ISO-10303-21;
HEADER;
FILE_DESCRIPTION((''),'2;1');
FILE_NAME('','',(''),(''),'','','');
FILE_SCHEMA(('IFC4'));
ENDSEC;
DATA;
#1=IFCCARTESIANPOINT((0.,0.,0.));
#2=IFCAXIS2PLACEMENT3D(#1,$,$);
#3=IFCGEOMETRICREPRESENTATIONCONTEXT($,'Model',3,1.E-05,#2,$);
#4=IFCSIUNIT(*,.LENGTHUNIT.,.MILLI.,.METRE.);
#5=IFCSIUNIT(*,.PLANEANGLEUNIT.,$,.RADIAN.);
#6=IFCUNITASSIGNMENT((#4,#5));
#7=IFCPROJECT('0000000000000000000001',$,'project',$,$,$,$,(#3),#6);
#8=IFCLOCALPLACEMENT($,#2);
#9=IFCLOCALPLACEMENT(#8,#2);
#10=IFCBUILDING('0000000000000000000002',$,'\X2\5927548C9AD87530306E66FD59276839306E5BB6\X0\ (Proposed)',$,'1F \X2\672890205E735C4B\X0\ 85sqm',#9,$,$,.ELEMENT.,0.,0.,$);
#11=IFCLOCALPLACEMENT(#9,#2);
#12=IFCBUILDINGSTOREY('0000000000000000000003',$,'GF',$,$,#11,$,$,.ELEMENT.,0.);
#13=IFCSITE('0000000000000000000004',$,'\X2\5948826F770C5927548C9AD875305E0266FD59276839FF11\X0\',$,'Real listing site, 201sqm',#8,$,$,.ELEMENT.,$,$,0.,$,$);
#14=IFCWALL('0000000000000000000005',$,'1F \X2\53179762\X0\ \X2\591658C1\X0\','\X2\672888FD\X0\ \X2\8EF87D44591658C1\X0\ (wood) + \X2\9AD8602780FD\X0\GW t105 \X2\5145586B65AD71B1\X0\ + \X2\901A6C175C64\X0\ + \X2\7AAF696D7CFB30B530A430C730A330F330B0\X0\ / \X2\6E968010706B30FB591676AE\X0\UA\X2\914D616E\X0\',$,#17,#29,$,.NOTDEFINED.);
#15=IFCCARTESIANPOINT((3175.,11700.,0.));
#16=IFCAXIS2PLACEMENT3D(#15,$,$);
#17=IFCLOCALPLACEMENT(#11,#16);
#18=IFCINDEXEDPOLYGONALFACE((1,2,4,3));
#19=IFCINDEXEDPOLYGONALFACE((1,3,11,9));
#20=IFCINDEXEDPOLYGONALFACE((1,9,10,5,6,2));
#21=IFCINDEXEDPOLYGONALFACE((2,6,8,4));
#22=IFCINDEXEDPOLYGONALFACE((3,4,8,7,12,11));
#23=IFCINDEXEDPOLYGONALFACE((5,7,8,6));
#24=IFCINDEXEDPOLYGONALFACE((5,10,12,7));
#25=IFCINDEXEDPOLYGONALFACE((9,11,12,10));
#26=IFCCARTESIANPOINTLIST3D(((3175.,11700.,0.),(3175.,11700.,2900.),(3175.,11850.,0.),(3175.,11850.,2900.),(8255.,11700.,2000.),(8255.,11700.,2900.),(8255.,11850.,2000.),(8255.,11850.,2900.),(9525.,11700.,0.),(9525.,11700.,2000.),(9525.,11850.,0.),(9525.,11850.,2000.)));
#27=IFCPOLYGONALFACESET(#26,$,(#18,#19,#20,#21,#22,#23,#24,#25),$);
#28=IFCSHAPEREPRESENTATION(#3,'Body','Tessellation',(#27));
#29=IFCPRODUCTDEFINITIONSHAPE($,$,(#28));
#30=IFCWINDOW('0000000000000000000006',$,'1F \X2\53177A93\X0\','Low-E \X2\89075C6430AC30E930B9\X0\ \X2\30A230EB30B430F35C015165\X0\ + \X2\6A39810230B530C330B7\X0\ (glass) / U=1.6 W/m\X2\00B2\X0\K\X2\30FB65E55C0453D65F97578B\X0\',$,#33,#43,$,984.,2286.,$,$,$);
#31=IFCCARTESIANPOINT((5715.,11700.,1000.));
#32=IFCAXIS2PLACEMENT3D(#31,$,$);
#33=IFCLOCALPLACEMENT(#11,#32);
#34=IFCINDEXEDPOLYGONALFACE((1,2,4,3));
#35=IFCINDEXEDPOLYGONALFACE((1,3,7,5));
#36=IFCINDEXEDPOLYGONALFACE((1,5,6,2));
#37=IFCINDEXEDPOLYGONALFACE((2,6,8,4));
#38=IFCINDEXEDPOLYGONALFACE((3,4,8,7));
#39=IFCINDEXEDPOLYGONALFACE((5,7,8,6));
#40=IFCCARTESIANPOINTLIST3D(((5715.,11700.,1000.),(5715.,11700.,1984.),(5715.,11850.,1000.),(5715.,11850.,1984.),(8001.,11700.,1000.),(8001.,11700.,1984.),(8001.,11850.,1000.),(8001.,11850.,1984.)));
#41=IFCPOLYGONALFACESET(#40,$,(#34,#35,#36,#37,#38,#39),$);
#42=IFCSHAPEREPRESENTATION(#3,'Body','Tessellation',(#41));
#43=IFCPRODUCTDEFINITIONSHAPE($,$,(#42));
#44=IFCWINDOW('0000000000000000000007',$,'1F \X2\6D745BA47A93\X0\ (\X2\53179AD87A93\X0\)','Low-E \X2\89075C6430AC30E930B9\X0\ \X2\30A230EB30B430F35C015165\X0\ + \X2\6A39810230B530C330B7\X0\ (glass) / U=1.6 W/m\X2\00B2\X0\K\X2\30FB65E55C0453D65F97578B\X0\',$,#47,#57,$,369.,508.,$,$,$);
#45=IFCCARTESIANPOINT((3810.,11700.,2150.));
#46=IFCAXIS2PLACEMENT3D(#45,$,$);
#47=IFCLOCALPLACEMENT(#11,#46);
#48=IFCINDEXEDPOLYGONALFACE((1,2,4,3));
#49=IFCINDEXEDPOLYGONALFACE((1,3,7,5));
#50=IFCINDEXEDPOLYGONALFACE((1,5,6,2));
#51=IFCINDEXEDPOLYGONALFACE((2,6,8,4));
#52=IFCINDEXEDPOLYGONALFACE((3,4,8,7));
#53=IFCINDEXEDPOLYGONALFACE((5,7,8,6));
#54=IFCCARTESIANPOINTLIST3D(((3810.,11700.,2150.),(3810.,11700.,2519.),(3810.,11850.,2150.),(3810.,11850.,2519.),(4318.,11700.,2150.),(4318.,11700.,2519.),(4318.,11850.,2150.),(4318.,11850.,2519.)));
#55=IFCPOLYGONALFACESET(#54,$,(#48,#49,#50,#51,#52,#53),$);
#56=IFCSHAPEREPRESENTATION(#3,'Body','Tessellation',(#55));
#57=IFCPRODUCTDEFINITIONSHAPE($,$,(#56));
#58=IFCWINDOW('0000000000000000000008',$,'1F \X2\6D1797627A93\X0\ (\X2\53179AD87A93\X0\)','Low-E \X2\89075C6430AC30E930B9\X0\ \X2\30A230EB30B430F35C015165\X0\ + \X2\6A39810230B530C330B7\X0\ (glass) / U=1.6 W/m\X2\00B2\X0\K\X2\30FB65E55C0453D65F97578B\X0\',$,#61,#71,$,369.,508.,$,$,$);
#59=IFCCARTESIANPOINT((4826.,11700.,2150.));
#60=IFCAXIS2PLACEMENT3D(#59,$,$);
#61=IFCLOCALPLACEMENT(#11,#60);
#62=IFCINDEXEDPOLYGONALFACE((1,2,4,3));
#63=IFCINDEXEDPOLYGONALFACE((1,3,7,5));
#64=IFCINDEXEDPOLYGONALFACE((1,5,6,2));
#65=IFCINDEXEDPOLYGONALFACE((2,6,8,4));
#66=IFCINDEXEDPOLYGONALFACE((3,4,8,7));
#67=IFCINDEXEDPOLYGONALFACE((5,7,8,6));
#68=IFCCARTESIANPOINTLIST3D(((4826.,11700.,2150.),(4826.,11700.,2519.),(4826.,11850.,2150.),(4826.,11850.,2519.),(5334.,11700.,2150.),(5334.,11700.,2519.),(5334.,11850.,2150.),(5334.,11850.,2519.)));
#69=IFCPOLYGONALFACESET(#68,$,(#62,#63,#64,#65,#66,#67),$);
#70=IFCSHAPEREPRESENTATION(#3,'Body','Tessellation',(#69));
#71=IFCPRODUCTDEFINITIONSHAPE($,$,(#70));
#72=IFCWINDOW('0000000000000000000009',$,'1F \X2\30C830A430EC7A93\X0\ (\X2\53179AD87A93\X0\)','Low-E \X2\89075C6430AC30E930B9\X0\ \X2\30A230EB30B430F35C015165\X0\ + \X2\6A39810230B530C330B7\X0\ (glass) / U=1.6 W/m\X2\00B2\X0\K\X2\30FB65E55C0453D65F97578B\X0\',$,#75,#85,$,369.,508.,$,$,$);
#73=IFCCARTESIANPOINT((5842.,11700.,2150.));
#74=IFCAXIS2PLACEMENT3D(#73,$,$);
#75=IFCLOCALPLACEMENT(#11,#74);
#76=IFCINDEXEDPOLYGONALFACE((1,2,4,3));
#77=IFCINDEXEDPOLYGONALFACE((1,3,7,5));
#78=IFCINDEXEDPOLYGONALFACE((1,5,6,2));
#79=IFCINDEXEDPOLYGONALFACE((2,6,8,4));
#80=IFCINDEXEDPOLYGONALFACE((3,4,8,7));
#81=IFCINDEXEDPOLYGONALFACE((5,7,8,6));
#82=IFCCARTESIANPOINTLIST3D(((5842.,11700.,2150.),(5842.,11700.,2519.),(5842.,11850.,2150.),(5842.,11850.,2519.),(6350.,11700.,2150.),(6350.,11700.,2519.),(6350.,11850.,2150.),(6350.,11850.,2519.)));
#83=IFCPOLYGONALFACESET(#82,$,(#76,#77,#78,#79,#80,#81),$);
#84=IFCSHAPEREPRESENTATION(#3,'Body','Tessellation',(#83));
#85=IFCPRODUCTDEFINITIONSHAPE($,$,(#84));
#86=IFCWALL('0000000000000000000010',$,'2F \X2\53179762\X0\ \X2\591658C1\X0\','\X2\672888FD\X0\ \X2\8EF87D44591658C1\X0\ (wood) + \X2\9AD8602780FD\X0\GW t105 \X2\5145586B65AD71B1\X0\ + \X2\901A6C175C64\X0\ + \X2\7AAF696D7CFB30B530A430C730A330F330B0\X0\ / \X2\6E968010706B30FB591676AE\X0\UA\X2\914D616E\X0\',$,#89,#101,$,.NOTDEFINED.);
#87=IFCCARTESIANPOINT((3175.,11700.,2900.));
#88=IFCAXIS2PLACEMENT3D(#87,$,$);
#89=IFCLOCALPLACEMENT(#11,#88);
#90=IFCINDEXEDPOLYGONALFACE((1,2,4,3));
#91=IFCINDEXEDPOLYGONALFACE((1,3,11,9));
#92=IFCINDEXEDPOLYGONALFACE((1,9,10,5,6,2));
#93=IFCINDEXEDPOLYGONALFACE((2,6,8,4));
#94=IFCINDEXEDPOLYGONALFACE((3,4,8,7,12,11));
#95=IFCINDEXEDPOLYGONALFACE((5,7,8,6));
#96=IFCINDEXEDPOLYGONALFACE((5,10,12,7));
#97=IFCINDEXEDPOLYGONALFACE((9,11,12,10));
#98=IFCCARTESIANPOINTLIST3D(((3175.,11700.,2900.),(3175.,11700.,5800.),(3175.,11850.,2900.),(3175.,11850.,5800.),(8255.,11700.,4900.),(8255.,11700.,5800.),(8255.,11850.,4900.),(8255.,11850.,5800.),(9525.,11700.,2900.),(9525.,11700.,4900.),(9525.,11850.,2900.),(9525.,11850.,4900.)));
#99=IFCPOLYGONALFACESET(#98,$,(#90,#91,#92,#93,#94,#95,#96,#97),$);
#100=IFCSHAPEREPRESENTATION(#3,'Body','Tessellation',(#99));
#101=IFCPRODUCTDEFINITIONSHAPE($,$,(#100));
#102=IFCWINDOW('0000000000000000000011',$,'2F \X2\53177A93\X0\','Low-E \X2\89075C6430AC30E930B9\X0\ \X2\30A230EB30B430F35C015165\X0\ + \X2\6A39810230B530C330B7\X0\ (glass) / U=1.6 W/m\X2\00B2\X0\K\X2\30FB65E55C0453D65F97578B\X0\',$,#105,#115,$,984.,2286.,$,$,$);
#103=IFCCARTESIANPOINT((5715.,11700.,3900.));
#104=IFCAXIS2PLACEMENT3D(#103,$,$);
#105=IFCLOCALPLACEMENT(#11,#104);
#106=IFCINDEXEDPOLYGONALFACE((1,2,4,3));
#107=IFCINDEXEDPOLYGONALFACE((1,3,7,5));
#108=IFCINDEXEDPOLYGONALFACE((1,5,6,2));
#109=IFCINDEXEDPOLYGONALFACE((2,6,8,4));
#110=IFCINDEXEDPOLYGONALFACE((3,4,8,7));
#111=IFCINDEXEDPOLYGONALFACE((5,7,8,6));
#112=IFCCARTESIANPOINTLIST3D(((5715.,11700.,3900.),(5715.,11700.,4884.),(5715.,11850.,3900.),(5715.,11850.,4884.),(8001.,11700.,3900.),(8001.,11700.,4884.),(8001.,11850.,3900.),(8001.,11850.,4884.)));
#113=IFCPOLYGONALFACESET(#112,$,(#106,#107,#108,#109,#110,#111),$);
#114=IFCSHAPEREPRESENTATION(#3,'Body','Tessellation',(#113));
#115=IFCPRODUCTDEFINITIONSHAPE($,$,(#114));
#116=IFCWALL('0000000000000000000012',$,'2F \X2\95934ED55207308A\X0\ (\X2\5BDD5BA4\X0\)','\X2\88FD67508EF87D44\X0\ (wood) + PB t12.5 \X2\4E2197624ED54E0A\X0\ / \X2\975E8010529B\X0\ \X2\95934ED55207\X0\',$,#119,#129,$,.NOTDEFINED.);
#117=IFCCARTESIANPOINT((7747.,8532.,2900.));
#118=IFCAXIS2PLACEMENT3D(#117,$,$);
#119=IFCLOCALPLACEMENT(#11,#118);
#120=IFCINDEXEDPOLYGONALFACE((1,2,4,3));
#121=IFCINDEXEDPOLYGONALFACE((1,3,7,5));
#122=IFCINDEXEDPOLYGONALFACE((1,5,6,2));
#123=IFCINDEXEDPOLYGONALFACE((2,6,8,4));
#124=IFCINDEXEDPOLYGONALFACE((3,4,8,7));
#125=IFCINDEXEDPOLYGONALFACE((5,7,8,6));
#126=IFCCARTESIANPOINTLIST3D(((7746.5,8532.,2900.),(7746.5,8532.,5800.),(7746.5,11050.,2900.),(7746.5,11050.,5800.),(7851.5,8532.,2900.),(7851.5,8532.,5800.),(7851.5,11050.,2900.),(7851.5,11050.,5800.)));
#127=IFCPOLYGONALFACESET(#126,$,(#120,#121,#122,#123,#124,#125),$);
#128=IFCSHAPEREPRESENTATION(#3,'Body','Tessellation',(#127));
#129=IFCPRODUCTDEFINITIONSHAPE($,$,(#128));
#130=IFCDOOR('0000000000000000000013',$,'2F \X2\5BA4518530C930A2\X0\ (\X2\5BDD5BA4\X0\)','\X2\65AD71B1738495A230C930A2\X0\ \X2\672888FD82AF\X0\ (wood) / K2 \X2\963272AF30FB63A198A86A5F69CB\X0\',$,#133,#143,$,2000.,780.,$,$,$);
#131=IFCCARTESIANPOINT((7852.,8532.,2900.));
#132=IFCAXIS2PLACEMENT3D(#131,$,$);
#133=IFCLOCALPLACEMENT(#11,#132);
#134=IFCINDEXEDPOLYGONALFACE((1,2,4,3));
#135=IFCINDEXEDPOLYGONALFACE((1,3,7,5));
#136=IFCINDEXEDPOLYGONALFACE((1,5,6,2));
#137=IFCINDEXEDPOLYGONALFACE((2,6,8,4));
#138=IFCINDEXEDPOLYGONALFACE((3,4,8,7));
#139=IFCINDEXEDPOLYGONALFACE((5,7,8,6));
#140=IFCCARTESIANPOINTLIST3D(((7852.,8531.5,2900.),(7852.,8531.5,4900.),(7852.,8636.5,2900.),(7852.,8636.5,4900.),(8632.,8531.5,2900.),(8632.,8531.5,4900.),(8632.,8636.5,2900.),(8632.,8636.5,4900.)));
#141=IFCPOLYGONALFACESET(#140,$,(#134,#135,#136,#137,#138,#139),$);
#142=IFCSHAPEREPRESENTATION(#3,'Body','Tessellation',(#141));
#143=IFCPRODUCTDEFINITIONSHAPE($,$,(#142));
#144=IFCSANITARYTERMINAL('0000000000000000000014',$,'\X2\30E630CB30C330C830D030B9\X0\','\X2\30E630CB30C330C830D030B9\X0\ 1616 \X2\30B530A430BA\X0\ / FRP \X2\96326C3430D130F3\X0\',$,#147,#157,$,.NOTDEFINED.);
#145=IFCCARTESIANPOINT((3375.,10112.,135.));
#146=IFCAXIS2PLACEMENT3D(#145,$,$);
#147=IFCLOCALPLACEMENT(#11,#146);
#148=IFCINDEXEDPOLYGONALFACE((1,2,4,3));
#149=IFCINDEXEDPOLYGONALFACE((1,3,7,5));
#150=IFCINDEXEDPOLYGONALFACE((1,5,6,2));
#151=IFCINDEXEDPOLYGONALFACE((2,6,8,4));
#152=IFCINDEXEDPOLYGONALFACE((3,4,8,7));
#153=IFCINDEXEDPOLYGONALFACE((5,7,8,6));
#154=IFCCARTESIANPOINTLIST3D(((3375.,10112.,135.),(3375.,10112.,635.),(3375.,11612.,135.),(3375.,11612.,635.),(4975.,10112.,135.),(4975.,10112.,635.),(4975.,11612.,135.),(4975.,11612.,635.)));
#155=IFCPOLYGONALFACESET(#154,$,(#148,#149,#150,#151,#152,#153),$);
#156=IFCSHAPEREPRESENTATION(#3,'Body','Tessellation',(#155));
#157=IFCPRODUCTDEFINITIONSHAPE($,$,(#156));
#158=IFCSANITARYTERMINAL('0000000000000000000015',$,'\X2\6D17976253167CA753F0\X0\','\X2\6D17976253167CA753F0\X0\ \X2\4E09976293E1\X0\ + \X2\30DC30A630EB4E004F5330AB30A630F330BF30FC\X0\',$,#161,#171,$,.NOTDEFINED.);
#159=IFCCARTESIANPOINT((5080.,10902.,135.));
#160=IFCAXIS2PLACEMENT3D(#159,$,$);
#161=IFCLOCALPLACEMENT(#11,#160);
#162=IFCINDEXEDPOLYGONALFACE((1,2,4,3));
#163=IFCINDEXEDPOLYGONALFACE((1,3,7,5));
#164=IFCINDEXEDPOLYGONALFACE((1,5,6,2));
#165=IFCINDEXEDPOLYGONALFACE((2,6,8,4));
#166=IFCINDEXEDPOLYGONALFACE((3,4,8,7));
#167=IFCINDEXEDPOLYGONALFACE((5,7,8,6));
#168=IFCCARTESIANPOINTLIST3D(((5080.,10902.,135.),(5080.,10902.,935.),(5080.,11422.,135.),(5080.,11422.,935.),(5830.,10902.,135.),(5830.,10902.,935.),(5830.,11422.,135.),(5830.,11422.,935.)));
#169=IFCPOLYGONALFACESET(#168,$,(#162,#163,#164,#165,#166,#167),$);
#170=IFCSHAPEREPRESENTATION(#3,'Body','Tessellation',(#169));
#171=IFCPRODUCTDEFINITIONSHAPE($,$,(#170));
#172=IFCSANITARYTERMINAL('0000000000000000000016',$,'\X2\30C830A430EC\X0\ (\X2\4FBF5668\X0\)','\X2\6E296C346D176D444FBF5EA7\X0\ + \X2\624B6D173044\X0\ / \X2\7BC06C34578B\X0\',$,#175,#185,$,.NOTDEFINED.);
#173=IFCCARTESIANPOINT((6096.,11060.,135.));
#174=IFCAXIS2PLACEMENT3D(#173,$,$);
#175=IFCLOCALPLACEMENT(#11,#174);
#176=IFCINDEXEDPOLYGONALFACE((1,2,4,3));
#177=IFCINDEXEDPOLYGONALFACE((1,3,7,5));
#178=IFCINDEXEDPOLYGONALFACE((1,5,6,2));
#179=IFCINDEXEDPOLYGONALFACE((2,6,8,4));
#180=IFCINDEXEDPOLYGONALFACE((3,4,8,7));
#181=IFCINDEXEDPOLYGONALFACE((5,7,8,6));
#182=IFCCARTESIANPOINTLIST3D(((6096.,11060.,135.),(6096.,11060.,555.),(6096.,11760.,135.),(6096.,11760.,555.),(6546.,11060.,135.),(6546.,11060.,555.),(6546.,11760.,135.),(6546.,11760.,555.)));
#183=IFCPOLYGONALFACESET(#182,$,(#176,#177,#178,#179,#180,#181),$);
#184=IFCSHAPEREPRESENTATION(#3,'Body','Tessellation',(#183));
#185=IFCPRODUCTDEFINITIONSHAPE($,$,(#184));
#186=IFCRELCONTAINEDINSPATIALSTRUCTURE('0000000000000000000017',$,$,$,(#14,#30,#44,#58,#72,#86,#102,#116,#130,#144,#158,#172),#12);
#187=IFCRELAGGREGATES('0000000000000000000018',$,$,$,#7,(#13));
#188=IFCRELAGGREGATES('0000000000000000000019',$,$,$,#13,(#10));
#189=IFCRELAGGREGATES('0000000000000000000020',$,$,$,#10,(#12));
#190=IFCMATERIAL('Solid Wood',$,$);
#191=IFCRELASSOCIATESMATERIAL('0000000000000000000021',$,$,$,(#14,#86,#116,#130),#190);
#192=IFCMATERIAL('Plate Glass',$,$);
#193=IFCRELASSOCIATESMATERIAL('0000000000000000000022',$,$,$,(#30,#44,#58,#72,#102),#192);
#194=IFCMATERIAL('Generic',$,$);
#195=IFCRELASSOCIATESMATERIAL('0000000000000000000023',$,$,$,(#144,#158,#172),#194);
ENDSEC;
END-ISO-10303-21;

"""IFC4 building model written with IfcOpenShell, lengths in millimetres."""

from ifc_helpers import new_model, si_unit, frame, frame_2d, origin, place, context, project, spatial, rectangle, extrude, material, element, fill, save


model = new_model("IFC4")

# Units and contexts
model_context = context("Model", 3, precision=1e-05, world=origin())
ifc_project = project(units=[si_unit("LENGTHUNIT", "METRE", prefix="MILLI"), si_unit("PLANEANGLEUNIT", "RADIAN")], contexts=[model_context])

# Site, building, storey
site_placement = place(None, origin())
site = spatial("IfcSite", under=ifc_project, at=site_placement, Name="奈良県大和高田市曽大根１", ObjectType="Real listing site, 201sqm", CompositionType="ELEMENT", RefElevation=0.0)
building_placement = place(site_placement, origin())
building = spatial("IfcBuilding", under=site, at=building_placement, Name="大和高田の曽大根の家 (Proposed)", ObjectType="1F 木造平屋 85sqm", CompositionType="ELEMENT", ElevationOfRefHeight=0.0, ElevationOfTerrain=0.0)
storey_placement = place(building_placement, origin())
storey = spatial("IfcBuildingStorey", under=building, at=storey_placement, Name="GF", CompositionType="ELEMENT", Elevation=0.0)

# Wall, openings, windows
ifc_material_1 = material(Name="Solid Wood")
wall_1_placement = place(storey_placement, frame((3175.0, 11700.0, 0.0)))
wall_1 = element("IfcWall", 1, at=wall_1_placement, inside=storey, material=ifc_material_1, Name="1F 北面 外壁", Description="木製 軸組外壁 (wood) + 高性能GW t105 充填断熱 + 通気層 + 窯業系サイディング / 準耐火・外皮UA配慮", PredefinedType="NOTDEFINED", context=model_context, shape_type="SweptSolid", body=[
    extrude(rectangle(XDim=6350.0, YDim=150.0, at=frame_2d((3175.0, 75.0))), frame((3175.0, 11700.0, 0.0)), (0.0, 0.0, 1.0), 2900.0),
])
opening_1_placement = place(storey_placement, frame((5715.0, 11700.0, 1000.0)))
opening_1 = element("IfcOpeningElement", 2, at=opening_1_placement, cuts=wall_1, PredefinedType="NOTDEFINED", context=model_context, shape_type="SweptSolid", body=[
    extrude(rectangle(XDim=2286.0, YDim=150.0, at=frame_2d((1143.0, 75.0))), frame((5715.0, 11700.0, 1000.0)), (0.0, 0.0, 1.0), 984.0),
])
opening_2_placement = place(storey_placement, frame((3810.0, 11700.0, 2150.0)))
opening_2 = element("IfcOpeningElement", 3, at=opening_2_placement, cuts=wall_1, PredefinedType="NOTDEFINED", context=model_context, shape_type="SweptSolid", body=[
    extrude(rectangle(XDim=508.0, YDim=150.0, at=frame_2d((254.0, 75.0))), frame((3810.0, 11700.0, 2150.0)), (0.0, 0.0, 1.0), 369.0),
])
opening_3_placement = place(storey_placement, frame((4826.0, 11700.0, 2150.0)))
opening_3 = element("IfcOpeningElement", 4, at=opening_3_placement, cuts=wall_1, PredefinedType="NOTDEFINED", context=model_context, shape_type="SweptSolid", body=[
    extrude(rectangle(XDim=508.0, YDim=150.0, at=frame_2d((254.0, 75.0))), frame((4826.0, 11700.0, 2150.0)), (0.0, 0.0, 1.0), 369.0),
])
opening_4_placement = place(storey_placement, frame((5842.0, 11700.0, 2150.0)))
opening_4 = element("IfcOpeningElement", 5, at=opening_4_placement, cuts=wall_1, PredefinedType="NOTDEFINED", context=model_context, shape_type="SweptSolid", body=[
    extrude(rectangle(XDim=508.0, YDim=150.0, at=frame_2d((254.0, 75.0))), frame((5842.0, 11700.0, 2150.0)), (0.0, 0.0, 1.0), 369.0),
])
ifc_material_2 = material(Name="Plate Glass")
window_1_placement = place(storey_placement, frame((5715.0, 11700.0, 1000.0)))
window_1 = element("IfcWindow", 6, at=window_1_placement, inside=storey, material=ifc_material_2, Name="1F 北窓", Description="Low-E 複層ガラス アルゴン封入 + 樹脂サッシ (glass) / U=1.6 W/m²K・日射取得型", OverallHeight=984.0, OverallWidth=2286.0, context=model_context, shape_type="SweptSolid", body=[
    extrude(rectangle(XDim=2286.0, YDim=150.0, at=frame_2d((1143.0, 75.0))), frame((5715.0, 11700.0, 1000.0)), (0.0, 0.0, 1.0), 984.0),
])
fill(opening_1, window_1)
window_2_placement = place(storey_placement, frame((3810.0, 11700.0, 2150.0)))
window_2 = element("IfcWindow", 7, at=window_2_placement, inside=storey, material=ifc_material_2, Name="1F 浴室窓 (北高窓)", Description="Low-E 複層ガラス アルゴン封入 + 樹脂サッシ (glass) / U=1.6 W/m²K・日射取得型", OverallHeight=369.0, OverallWidth=508.0, context=model_context, shape_type="SweptSolid", body=[
    extrude(rectangle(XDim=508.0, YDim=150.0, at=frame_2d((254.0, 75.0))), frame((3810.0, 11700.0, 2150.0)), (0.0, 0.0, 1.0), 369.0),
])
fill(opening_2, window_2)
window_3_placement = place(storey_placement, frame((4826.0, 11700.0, 2150.0)))
window_3 = element("IfcWindow", 8, at=window_3_placement, inside=storey, material=ifc_material_2, Name="1F 洗面窓 (北高窓)", Description="Low-E 複層ガラス アルゴン封入 + 樹脂サッシ (glass) / U=1.6 W/m²K・日射取得型", OverallHeight=369.0, OverallWidth=508.0, context=model_context, shape_type="SweptSolid", body=[
    extrude(rectangle(XDim=508.0, YDim=150.0, at=frame_2d((254.0, 75.0))), frame((4826.0, 11700.0, 2150.0)), (0.0, 0.0, 1.0), 369.0),
])
fill(opening_3, window_3)
window_4_placement = place(storey_placement, frame((5842.0, 11700.0, 2150.0)))
window_4 = element("IfcWindow", 9, at=window_4_placement, inside=storey, material=ifc_material_2, Name="1F トイレ窓 (北高窓)", Description="Low-E 複層ガラス アルゴン封入 + 樹脂サッシ (glass) / U=1.6 W/m²K・日射取得型", OverallHeight=369.0, OverallWidth=508.0, context=model_context, shape_type="SweptSolid", body=[
    extrude(rectangle(XDim=508.0, YDim=150.0, at=frame_2d((254.0, 75.0))), frame((5842.0, 11700.0, 2150.0)), (0.0, 0.0, 1.0), 369.0),
])
fill(opening_4, window_4)

# Wall, opening, window
wall_2_placement = place(storey_placement, frame((3175.0, 11700.0, 2900.0)))
wall_2 = element("IfcWall", 10, at=wall_2_placement, inside=storey, material=ifc_material_1, Name="2F 北面 外壁", Description="木製 軸組外壁 (wood) + 高性能GW t105 充填断熱 + 通気層 + 窯業系サイディング / 準耐火・外皮UA配慮", PredefinedType="NOTDEFINED", context=model_context, shape_type="SweptSolid", body=[
    extrude(rectangle(XDim=6350.0, YDim=150.0, at=frame_2d((3175.0, 75.0))), frame((3175.0, 11700.0, 2900.0)), (0.0, 0.0, 1.0), 2900.0),
])
opening_5_placement = place(storey_placement, frame((5715.0, 11700.0, 3900.0)))
opening_5 = element("IfcOpeningElement", 11, at=opening_5_placement, cuts=wall_2, PredefinedType="NOTDEFINED", context=model_context, shape_type="SweptSolid", body=[
    extrude(rectangle(XDim=2286.0, YDim=150.0, at=frame_2d((1143.0, 75.0))), frame((5715.0, 11700.0, 3900.0)), (0.0, 0.0, 1.0), 984.0),
])
window_5_placement = place(storey_placement, frame((5715.0, 11700.0, 3900.0)))
window_5 = element("IfcWindow", 12, at=window_5_placement, inside=storey, material=ifc_material_2, Name="2F 北窓", Description="Low-E 複層ガラス アルゴン封入 + 樹脂サッシ (glass) / U=1.6 W/m²K・日射取得型", OverallHeight=984.0, OverallWidth=2286.0, context=model_context, shape_type="SweptSolid", body=[
    extrude(rectangle(XDim=2286.0, YDim=150.0, at=frame_2d((1143.0, 75.0))), frame((5715.0, 11700.0, 3900.0)), (0.0, 0.0, 1.0), 984.0),
])
fill(opening_5, window_5)

# Wall
wall_3_placement = place(storey_placement, frame((7747.0, 8532.0, 2900.0)))
element("IfcWall", 13, at=wall_3_placement, inside=storey, material=ifc_material_1, Name="2F 間仕切り (寝室)", Description="製材軸組 (wood) + PB t12.5 両面仕上 / 非耐力 間仕切", PredefinedType="NOTDEFINED", context=model_context, shape_type="SweptSolid", body=[
    extrude(rectangle(XDim=105.0, YDim=2518.0, at=frame_2d((52.0, 1259.0))), frame((7747.0, 8532.0, 2900.0)), (0.0, 0.0, 1.0), 2900.0),
])

# Door
door_1_placement = place(storey_placement, frame((7852.0, 8532.0, 2900.0)))
element("IfcDoor", 14, at=door_1_placement, inside=storey, material=ifc_material_1, Name="2F 室内ドア (寝室)", Description="断熱玄関ドア 木製芯 (wood) / K2 防犯・採風機構", OverallHeight=2000.0, OverallWidth=780.0, context=model_context, shape_type="SweptSolid", body=[
    extrude(rectangle(XDim=780.0, YDim=105.0, at=frame_2d((390.0, 52.0))), frame((7852.0, 8532.0, 2900.0)), (0.0, 0.0, 1.0), 2000.0),
])

# Sanitary terminals
ifc_material_3 = material(Name="Generic")
sanitary_terminal_1_placement = place(storey_placement, frame((3375.0, 10112.0, 135.0)))
element("IfcSanitaryTerminal", 15, at=sanitary_terminal_1_placement, inside=storey, material=ifc_material_3, Name="ユニットバス", Description="ユニットバス 1616 サイズ / FRP 防水パン", PredefinedType="NOTDEFINED", context=model_context, shape_type="SweptSolid", body=[
    extrude(rectangle(XDim=1600.0, YDim=1500.0, at=frame_2d((800.0, 750.0))), frame((3375.0, 10112.0, 135.0)), (0.0, 0.0, 1.0), 500.0),
])
sanitary_terminal_2_placement = place(storey_placement, frame((5080.0, 10902.0, 135.0)))
element("IfcSanitaryTerminal", 16, at=sanitary_terminal_2_placement, inside=storey, material=ifc_material_3, Name="洗面化粧台", Description="洗面化粧台 三面鏡 + ボウル一体カウンター", PredefinedType="NOTDEFINED", context=model_context, shape_type="SweptSolid", body=[
    extrude(rectangle(XDim=750.0, YDim=520.0, at=frame_2d((375.0, 260.0))), frame((5080.0, 10902.0, 135.0)), (0.0, 0.0, 1.0), 800.0),
])
sanitary_terminal_3_placement = place(storey_placement, frame((6096.0, 11060.0, 135.0)))
element("IfcSanitaryTerminal", 17, at=sanitary_terminal_3_placement, inside=storey, material=ifc_material_3, Name="トイレ (便器)", Description="温水洗浄便座 + 手洗い / 節水型", PredefinedType="NOTDEFINED", context=model_context, shape_type="SweptSolid", body=[
    extrude(rectangle(XDim=450.0, YDim=700.0, at=frame_2d((225.0, 350.0))), frame((6096.0, 11060.0, 135.0)), (0.0, 0.0, 1.0), 420.0),
])

save(model, "model.ifc")
